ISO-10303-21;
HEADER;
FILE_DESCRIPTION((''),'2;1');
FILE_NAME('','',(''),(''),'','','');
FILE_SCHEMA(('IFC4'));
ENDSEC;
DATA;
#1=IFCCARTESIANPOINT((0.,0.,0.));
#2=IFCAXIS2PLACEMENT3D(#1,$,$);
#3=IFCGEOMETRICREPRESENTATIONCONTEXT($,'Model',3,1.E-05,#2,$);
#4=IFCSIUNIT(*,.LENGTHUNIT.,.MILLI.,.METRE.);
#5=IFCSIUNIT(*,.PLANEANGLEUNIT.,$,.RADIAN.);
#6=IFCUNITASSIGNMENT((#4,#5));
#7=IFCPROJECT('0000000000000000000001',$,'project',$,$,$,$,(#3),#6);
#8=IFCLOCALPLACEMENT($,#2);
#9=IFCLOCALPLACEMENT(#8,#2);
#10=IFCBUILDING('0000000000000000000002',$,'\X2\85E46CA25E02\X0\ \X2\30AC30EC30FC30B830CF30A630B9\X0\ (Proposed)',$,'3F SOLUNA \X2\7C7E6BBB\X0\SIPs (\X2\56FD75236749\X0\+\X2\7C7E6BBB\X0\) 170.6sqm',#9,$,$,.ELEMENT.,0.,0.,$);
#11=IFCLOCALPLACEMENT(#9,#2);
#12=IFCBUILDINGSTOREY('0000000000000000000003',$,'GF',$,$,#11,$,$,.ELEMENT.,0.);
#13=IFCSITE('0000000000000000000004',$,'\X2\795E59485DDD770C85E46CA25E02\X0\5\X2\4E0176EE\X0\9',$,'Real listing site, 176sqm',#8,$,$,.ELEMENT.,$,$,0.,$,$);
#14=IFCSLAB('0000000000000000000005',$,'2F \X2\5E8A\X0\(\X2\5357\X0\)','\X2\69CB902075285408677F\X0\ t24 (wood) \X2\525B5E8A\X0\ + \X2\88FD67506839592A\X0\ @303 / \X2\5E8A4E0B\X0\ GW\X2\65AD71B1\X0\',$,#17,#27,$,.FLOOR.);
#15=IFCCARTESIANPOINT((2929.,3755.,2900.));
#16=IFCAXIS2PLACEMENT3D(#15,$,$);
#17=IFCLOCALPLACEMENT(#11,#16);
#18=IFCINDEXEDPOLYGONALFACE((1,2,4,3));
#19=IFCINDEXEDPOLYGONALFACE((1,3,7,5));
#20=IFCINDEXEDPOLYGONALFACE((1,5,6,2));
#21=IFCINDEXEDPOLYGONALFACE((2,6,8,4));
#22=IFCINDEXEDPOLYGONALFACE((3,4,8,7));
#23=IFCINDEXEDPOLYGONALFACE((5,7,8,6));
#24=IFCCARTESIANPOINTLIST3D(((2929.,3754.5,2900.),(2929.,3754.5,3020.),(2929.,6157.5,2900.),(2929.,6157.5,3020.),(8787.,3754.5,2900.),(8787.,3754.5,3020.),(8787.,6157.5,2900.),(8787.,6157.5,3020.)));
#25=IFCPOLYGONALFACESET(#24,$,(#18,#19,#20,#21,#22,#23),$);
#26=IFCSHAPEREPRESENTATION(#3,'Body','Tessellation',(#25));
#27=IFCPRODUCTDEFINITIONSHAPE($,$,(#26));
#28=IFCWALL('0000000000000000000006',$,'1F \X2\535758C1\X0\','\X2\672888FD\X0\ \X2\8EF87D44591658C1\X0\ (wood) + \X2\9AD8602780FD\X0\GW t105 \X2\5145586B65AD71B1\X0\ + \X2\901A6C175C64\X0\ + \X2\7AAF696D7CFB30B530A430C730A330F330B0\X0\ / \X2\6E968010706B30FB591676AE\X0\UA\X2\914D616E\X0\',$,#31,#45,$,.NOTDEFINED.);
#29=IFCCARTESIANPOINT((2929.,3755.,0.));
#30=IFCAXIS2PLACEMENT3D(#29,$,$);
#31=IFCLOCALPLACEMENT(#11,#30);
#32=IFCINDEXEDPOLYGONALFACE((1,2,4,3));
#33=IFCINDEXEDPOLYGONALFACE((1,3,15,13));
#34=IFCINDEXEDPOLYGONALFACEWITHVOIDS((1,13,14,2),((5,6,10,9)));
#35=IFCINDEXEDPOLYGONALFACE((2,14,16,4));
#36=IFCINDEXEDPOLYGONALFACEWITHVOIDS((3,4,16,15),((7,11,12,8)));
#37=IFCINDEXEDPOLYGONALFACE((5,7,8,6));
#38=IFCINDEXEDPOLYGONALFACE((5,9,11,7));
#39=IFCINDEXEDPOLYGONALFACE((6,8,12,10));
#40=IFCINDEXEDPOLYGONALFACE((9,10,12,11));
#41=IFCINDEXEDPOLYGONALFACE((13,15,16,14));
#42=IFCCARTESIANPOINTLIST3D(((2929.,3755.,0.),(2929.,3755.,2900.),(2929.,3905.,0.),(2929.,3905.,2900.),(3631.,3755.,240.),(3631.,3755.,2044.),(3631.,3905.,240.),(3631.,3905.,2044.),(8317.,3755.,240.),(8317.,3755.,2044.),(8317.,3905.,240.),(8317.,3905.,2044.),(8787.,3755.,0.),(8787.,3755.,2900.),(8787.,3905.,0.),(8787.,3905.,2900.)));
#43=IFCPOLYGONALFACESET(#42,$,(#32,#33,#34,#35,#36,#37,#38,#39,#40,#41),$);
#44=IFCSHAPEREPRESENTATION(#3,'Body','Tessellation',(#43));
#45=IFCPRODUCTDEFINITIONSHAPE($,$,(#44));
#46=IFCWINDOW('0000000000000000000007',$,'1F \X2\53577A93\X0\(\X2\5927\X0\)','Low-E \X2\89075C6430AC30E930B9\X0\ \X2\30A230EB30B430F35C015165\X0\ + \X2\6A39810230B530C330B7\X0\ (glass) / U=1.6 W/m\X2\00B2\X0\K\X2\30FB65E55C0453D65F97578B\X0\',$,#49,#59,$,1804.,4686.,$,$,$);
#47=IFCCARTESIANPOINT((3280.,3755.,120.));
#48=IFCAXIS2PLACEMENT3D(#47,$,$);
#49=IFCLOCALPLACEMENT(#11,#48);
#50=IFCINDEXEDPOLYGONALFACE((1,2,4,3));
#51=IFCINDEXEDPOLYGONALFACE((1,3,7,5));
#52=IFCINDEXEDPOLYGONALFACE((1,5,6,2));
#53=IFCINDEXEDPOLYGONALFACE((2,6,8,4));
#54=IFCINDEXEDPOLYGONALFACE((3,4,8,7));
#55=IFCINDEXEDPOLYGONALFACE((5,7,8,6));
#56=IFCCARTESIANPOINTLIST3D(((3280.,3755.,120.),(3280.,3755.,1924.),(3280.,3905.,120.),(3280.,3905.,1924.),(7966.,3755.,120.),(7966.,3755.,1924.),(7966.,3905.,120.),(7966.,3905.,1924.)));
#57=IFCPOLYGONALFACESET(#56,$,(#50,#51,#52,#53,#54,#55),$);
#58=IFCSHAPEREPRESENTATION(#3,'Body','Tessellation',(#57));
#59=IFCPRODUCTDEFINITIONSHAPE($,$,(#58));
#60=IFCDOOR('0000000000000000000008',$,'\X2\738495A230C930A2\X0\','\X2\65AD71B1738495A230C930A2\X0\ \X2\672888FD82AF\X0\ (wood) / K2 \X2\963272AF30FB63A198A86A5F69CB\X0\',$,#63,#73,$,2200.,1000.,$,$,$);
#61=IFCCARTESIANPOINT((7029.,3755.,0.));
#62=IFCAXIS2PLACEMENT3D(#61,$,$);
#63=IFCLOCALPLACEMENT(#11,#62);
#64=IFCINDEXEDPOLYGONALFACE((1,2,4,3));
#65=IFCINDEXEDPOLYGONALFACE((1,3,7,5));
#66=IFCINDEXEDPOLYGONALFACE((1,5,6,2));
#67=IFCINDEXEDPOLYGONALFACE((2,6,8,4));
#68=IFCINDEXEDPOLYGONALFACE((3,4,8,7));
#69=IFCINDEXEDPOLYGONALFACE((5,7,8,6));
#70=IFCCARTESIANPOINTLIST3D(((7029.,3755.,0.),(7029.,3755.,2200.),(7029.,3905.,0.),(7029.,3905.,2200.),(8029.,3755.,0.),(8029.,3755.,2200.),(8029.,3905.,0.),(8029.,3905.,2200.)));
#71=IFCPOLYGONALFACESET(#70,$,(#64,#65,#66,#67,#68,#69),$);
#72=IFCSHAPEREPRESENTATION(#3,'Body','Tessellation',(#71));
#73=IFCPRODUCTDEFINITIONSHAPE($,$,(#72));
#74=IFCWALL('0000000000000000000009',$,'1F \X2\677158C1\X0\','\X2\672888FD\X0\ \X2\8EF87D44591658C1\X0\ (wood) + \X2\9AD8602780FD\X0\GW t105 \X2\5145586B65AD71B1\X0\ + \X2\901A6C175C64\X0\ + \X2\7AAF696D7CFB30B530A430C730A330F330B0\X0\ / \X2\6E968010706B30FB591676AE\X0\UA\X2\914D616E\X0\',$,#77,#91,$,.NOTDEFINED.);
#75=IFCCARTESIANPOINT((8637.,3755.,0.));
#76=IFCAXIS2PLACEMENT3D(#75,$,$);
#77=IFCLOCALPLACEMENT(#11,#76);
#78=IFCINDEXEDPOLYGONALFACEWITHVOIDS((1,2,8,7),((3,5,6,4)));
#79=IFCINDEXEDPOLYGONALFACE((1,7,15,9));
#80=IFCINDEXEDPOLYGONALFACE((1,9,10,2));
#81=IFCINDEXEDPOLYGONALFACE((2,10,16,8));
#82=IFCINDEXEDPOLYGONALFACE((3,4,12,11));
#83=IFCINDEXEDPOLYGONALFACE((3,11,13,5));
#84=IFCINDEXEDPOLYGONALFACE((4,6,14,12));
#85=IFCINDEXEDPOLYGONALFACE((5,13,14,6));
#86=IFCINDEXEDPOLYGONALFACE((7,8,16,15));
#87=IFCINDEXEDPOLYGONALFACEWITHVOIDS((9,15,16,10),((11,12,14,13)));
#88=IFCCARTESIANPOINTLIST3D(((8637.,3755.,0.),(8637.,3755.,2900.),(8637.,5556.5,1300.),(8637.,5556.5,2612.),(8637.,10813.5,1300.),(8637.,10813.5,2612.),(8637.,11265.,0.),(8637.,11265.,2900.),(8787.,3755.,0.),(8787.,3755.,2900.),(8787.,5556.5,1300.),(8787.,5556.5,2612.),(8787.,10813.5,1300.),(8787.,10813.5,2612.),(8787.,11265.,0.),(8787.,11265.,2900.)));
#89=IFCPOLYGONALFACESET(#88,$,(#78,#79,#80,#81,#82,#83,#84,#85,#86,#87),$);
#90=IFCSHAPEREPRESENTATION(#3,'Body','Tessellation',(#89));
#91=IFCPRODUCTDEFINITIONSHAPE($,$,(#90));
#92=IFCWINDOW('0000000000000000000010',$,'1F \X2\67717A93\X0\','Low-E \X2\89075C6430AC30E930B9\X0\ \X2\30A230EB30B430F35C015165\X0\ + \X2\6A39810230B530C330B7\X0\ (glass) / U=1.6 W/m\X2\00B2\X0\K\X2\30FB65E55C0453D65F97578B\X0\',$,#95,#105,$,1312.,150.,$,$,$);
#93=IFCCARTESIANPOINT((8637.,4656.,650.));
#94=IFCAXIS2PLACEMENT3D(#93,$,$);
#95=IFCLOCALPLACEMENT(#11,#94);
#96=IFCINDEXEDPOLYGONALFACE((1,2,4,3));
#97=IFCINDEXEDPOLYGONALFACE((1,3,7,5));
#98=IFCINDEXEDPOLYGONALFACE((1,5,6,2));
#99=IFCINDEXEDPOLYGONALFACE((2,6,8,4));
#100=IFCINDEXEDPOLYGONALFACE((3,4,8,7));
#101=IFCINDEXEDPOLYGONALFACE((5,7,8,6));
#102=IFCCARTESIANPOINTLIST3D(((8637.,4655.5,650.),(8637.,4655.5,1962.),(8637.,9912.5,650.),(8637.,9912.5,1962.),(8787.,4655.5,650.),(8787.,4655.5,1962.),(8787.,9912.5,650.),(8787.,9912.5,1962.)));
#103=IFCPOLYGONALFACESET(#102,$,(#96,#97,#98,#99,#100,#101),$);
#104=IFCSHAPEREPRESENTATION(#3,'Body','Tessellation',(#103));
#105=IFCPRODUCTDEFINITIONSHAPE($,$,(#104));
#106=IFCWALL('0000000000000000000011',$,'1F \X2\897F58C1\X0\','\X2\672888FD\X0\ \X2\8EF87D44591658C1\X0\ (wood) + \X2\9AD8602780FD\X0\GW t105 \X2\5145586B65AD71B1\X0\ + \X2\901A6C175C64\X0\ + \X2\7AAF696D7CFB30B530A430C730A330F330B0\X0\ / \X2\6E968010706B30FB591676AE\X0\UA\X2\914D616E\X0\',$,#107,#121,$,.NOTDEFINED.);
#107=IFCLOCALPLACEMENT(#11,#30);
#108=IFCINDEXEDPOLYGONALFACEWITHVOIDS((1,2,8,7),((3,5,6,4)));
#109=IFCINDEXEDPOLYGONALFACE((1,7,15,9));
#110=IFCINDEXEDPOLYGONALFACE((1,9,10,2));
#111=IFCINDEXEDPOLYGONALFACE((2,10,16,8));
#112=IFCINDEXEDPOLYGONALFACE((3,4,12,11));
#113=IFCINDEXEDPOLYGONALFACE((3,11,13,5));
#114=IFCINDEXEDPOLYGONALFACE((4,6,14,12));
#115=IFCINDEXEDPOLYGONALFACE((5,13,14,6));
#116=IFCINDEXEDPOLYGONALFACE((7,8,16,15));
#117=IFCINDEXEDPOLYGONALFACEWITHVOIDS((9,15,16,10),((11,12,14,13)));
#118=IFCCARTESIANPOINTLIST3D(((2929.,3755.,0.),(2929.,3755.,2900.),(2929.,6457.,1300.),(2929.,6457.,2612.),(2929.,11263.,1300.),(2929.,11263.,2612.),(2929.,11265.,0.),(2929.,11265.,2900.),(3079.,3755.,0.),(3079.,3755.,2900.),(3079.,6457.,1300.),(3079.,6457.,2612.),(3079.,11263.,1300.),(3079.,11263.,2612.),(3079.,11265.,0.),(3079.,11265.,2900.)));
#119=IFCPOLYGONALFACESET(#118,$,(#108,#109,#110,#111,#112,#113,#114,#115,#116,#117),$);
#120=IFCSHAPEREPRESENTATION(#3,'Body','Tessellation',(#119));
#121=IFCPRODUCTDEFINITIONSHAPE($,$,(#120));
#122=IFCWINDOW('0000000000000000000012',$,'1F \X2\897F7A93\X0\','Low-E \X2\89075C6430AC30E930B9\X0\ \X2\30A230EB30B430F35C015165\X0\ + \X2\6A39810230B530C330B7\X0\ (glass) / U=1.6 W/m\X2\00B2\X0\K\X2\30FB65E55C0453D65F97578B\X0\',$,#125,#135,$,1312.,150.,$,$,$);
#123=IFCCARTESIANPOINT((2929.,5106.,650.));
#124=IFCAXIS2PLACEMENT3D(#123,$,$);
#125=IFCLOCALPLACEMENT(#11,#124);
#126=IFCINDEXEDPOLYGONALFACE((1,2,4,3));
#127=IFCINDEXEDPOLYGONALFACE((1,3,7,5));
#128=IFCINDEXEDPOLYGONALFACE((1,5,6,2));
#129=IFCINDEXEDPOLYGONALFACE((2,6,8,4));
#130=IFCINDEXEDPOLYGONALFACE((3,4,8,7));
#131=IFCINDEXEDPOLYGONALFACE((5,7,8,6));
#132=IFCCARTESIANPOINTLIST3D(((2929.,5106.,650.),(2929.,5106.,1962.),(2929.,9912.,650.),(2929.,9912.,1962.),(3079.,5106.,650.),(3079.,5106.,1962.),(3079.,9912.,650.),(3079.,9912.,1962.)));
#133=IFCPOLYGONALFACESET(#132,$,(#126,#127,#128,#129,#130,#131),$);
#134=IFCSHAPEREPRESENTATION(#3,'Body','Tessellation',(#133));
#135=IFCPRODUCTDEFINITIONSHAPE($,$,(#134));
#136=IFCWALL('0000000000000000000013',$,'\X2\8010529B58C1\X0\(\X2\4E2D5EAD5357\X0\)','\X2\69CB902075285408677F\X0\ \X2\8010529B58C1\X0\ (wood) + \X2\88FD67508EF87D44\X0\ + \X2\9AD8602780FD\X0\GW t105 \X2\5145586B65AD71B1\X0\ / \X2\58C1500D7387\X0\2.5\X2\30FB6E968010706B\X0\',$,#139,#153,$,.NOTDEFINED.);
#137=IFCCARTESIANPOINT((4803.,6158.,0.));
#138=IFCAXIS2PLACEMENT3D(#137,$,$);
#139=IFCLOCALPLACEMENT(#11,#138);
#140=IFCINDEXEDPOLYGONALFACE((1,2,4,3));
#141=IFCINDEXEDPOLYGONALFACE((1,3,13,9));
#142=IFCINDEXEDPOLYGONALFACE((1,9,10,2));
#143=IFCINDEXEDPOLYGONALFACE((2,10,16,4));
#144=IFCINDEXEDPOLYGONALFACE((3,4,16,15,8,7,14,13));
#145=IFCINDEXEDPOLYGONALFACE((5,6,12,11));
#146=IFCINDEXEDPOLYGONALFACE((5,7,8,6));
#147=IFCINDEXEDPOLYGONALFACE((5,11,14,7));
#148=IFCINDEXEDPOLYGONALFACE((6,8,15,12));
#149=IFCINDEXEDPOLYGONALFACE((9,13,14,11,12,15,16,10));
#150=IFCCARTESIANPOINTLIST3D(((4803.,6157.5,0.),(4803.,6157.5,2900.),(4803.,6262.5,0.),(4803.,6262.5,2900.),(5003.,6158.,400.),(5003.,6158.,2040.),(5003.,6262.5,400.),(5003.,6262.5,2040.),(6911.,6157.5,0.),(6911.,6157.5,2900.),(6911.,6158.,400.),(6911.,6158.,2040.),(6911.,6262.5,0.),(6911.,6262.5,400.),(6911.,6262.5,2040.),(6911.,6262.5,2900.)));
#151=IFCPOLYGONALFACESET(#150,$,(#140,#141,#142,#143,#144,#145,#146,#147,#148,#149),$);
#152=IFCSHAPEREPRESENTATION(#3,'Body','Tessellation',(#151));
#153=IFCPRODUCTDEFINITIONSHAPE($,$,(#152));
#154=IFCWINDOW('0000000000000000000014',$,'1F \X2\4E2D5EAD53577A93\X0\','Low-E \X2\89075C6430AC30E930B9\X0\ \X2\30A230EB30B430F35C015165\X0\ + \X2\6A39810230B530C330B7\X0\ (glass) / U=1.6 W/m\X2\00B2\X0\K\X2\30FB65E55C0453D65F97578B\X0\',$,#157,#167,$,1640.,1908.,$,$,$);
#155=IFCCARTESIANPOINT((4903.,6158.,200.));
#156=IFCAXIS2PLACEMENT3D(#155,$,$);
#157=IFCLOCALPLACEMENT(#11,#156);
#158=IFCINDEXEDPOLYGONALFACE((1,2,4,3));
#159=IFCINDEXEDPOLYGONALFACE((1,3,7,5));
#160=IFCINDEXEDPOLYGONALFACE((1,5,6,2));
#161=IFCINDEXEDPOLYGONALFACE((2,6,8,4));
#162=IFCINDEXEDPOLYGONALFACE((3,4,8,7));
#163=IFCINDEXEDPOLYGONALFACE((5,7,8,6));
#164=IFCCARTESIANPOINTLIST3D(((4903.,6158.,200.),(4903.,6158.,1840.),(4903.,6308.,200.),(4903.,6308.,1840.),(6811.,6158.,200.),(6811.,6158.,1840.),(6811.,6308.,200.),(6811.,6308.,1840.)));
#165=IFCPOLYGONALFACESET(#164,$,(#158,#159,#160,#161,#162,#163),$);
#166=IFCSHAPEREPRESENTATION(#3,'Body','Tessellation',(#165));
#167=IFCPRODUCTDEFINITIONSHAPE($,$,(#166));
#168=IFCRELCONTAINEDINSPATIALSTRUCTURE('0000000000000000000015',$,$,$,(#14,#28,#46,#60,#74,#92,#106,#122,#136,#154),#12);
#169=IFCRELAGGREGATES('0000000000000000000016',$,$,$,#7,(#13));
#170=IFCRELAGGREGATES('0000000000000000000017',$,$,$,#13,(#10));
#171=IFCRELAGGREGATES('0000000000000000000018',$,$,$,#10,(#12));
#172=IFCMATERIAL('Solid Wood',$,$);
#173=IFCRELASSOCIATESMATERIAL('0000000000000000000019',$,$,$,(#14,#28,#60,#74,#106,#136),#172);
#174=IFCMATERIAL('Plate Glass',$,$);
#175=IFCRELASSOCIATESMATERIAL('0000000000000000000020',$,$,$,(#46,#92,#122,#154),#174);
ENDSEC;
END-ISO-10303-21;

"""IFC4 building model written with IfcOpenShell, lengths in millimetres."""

from ifc_helpers import new_model, si_unit, frame, frame_2d, origin, place, context, project, spatial, rectangle, extrude, material, element, fill, save


model = new_model("IFC4")

# Units and contexts
model_context = context("Model", 3, precision=1e-05, world=origin())
ifc_project = project(units=[si_unit("LENGTHUNIT", "METRE", prefix="MILLI"), si_unit("PLANEANGLEUNIT", "RADIAN")], contexts=[model_context])

# Site, building, storey
site_placement = place(None, origin())
site = spatial("IfcSite", under=ifc_project, at=site_placement, Name="神奈川県藤沢市5丁目9", ObjectType="Real listing site, 176sqm", CompositionType="ELEMENT", RefElevation=0.0)
building_placement = place(site_placement, origin())
building = spatial("IfcBuilding", under=site, at=building_placement, Name="藤沢市 ガレージハウス (Proposed)", ObjectType="3F SOLUNA 籾殻SIPs (国産杉+籾殻) 170.6sqm", CompositionType="ELEMENT", ElevationOfRefHeight=0.0, ElevationOfTerrain=0.0)
storey_placement = place(building_placement, origin())
storey = spatial("IfcBuildingStorey", under=building, at=storey_placement, Name="GF", CompositionType="ELEMENT", Elevation=0.0)

# Slab
ifc_material_1 = material(Name="Solid Wood")
slab_1_placement = place(storey_placement, frame((2929.0, 3755.0, 2900.0)))
element("IfcSlab", 1, at=slab_1_placement, inside=storey, material=ifc_material_1, Name="2F 床(南)", Description="構造用合板 t24 (wood) 剛床 + 製材根太 @303 / 床下 GW断熱", PredefinedType="FLOOR", context=model_context, shape_type="SweptSolid", body=[
    extrude(rectangle(XDim=5858.0, YDim=2403.0, at=frame_2d((2929.0, 1201.0))), frame((2929.0, 3755.0, 2900.0)), (0.0, 0.0, 1.0), 120.0),
])

# Wall, openings, window, door
wall_1_placement = place(storey_placement, frame((2929.0, 3755.0, 0.0)))
wall_1 = element("IfcWall", 2, at=wall_1_placement, inside=storey, material=ifc_material_1, Name="1F 南壁", Description="木製 軸組外壁 (wood) + 高性能GW t105 充填断熱 + 通気層 + 窯業系サイディング / 準耐火・外皮UA配慮", PredefinedType="NOTDEFINED", context=model_context, shape_type="SweptSolid", body=[
    extrude(rectangle(XDim=5858.0, YDim=150.0, at=frame_2d((2929.0, 75.0))), frame((2929.0, 3755.0, 0.0)), (0.0, 0.0, 1.0), 2900.0),
])
opening_1_placement = place(storey_placement, frame((3280.0, 3755.0, 120.0)))
opening_1 = element("IfcOpeningElement", 3, at=opening_1_placement, cuts=wall_1, PredefinedType="NOTDEFINED", context=model_context, shape_type="SweptSolid", body=[
    extrude(rectangle(XDim=4686.0, YDim=150.0, at=frame_2d((2343.0, 75.0))), frame((3280.0, 3755.0, 120.0)), (0.0, 0.0, 1.0), 1804.0),
])
opening_2_placement = place(storey_placement, frame((7029.0, 3755.0, 0.0)))
opening_2 = element("IfcOpeningElement", 4, at=opening_2_placement, cuts=wall_1, PredefinedType="NOTDEFINED", context=model_context, shape_type="SweptSolid", body=[
    extrude(rectangle(XDim=1000.0, YDim=150.0, at=frame_2d((500.0, 75.0))), frame((7029.0, 3755.0, 0.0)), (0.0, 0.0, 1.0), 2200.0),
])
ifc_material_2 = material(Name="Plate Glass")
window_1_placement = place(storey_placement, frame((3280.0, 3755.0, 120.0)))
window_1 = element("IfcWindow", 5, at=window_1_placement, inside=storey, material=ifc_material_2, Name="1F 南窓(大)", Description="Low-E 複層ガラス アルゴン封入 + 樹脂サッシ (glass) / U=1.6 W/m²K・日射取得型", OverallHeight=1804.0, OverallWidth=4686.0, context=model_context, shape_type="SweptSolid", body=[
    extrude(rectangle(XDim=4686.0, YDim=150.0, at=frame_2d((2343.0, 75.0))), frame((3280.0, 3755.0, 120.0)), (0.0, 0.0, 1.0), 1804.0),
])
fill(opening_1, window_1)
door_placement = place(storey_placement, frame((7029.0, 3755.0, 0.0)))
door = element("IfcDoor", 6, at=door_placement, inside=storey, material=ifc_material_1, Name="玄関ドア", Description="断熱玄関ドア 木製芯 (wood) / K2 防犯・採風機構", OverallHeight=2200.0, OverallWidth=1000.0, context=model_context, shape_type="SweptSolid", body=[
    extrude(rectangle(XDim=1000.0, YDim=150.0, at=frame_2d((500.0, 75.0))), frame((7029.0, 3755.0, 0.0)), (0.0, 0.0, 1.0), 2200.0),
])
fill(opening_2, door)

# Walls, openings, windows
wall_2_placement = place(storey_placement, frame((8637.0, 3755.0, 0.0)))
wall_2 = element("IfcWall", 7, at=wall_2_placement, inside=storey, material=ifc_material_1, Name="1F 東壁", Description="木製 軸組外壁 (wood) + 高性能GW t105 充填断熱 + 通気層 + 窯業系サイディング / 準耐火・外皮UA配慮", PredefinedType="NOTDEFINED", context=model_context, shape_type="SweptSolid", body=[
    extrude(rectangle(XDim=150.0, YDim=7510.0, at=frame_2d((75.0, 3755.0))), frame((8637.0, 3755.0, 0.0)), (0.0, 0.0, 1.0), 2900.0),
])
opening_3_placement = place(storey_placement, frame((8637.0, 4656.0, 650.0)))
opening_3 = element("IfcOpeningElement", 8, at=opening_3_placement, cuts=wall_2, PredefinedType="NOTDEFINED", context=model_context, shape_type="SweptSolid", body=[
    extrude(rectangle(XDim=150.0, YDim=5257.0, at=frame_2d((75.0, 2628.0))), frame((8637.0, 4656.0, 650.0)), (0.0, 0.0, 1.0), 1312.0),
])
window_2_placement = place(storey_placement, frame((8637.0, 4656.0, 650.0)))
window_2 = element("IfcWindow", 9, at=window_2_placement, inside=storey, material=ifc_material_2, Name="1F 東窓", Description="Low-E 複層ガラス アルゴン封入 + 樹脂サッシ (glass) / U=1.6 W/m²K・日射取得型", OverallHeight=1312.0, OverallWidth=150.0, context=model_context, shape_type="SweptSolid", body=[
    extrude(rectangle(XDim=150.0, YDim=5257.0, at=frame_2d((75.0, 2628.0))), frame((8637.0, 4656.0, 650.0)), (0.0, 0.0, 1.0), 1312.0),
])
fill(opening_3, window_2)
wall_3_placement = place(storey_placement, frame((2929.0, 3755.0, 0.0)))
wall_3 = element("IfcWall", 10, at=wall_3_placement, inside=storey, material=ifc_material_1, Name="1F 西壁", Description="木製 軸組外壁 (wood) + 高性能GW t105 充填断熱 + 通気層 + 窯業系サイディング / 準耐火・外皮UA配慮", PredefinedType="NOTDEFINED", context=model_context, shape_type="SweptSolid", body=[
    extrude(rectangle(XDim=150.0, YDim=7510.0, at=frame_2d((75.0, 3755.0))), frame((2929.0, 3755.0, 0.0)), (0.0, 0.0, 1.0), 2900.0),
])
opening_4_placement = place(storey_placement, frame((2929.0, 5106.0, 650.0)))
opening_4 = element("IfcOpeningElement", 11, at=opening_4_placement, cuts=wall_3, PredefinedType="NOTDEFINED", context=model_context, shape_type="SweptSolid", body=[
    extrude(rectangle(XDim=150.0, YDim=4806.0, at=frame_2d((75.0, 2403.0))), frame((2929.0, 5106.0, 650.0)), (0.0, 0.0, 1.0), 1312.0),
])
window_3_placement = place(storey_placement, frame((2929.0, 5106.0, 650.0)))
window_3 = element("IfcWindow", 12, at=window_3_placement, inside=storey, material=ifc_material_2, Name="1F 西窓", Description="Low-E 複層ガラス アルゴン封入 + 樹脂サッシ (glass) / U=1.6 W/m²K・日射取得型", OverallHeight=1312.0, OverallWidth=150.0, context=model_context, shape_type="SweptSolid", body=[
    extrude(rectangle(XDim=150.0, YDim=4806.0, at=frame_2d((75.0, 2403.0))), frame((2929.0, 5106.0, 650.0)), (0.0, 0.0, 1.0), 1312.0),
])
fill(opening_4, window_3)
wall_4_placement = place(storey_placement, frame((4803.0, 6158.0, 0.0)))
wall_4 = element("IfcWall", 13, at=wall_4_placement, inside=storey, material=ifc_material_1, Name="耐力壁(中庭南)", Description="構造用合板 耐力壁 (wood) + 製材軸組 + 高性能GW t105 充填断熱 / 壁倍率2.5・準耐火", PredefinedType="NOTDEFINED", context=model_context, shape_type="SweptSolid", body=[
    extrude(rectangle(XDim=2108.0, YDim=105.0, at=frame_2d((1054.0, 52.0))), frame((4803.0, 6158.0, 0.0)), (0.0, 0.0, 1.0), 2900.0),
])
opening_5_placement = place(storey_placement, frame((4903.0, 6158.0, 200.0)))
opening_5 = element("IfcOpeningElement", 14, at=opening_5_placement, cuts=wall_4, PredefinedType="NOTDEFINED", context=model_context, shape_type="SweptSolid", body=[
    extrude(rectangle(XDim=1908.0, YDim=150.0, at=frame_2d((954.0, 75.0))), frame((4903.0, 6158.0, 200.0)), (0.0, 0.0, 1.0), 1640.0),
])
window_4_placement = place(storey_placement, frame((4903.0, 6158.0, 200.0)))
window_4 = element("IfcWindow", 15, at=window_4_placement, inside=storey, material=ifc_material_2, Name="1F 中庭南窓", Description="Low-E 複層ガラス アルゴン封入 + 樹脂サッシ (glass) / U=1.6 W/m²K・日射取得型", OverallHeight=1640.0, OverallWidth=1908.0, context=model_context, shape_type="SweptSolid", body=[
    extrude(rectangle(XDim=1908.0, YDim=150.0, at=frame_2d((954.0, 75.0))), frame((4903.0, 6158.0, 200.0)), (0.0, 0.0, 1.0), 1640.0),
])
fill(opening_5, window_4)

save(model, "model.ifc")
